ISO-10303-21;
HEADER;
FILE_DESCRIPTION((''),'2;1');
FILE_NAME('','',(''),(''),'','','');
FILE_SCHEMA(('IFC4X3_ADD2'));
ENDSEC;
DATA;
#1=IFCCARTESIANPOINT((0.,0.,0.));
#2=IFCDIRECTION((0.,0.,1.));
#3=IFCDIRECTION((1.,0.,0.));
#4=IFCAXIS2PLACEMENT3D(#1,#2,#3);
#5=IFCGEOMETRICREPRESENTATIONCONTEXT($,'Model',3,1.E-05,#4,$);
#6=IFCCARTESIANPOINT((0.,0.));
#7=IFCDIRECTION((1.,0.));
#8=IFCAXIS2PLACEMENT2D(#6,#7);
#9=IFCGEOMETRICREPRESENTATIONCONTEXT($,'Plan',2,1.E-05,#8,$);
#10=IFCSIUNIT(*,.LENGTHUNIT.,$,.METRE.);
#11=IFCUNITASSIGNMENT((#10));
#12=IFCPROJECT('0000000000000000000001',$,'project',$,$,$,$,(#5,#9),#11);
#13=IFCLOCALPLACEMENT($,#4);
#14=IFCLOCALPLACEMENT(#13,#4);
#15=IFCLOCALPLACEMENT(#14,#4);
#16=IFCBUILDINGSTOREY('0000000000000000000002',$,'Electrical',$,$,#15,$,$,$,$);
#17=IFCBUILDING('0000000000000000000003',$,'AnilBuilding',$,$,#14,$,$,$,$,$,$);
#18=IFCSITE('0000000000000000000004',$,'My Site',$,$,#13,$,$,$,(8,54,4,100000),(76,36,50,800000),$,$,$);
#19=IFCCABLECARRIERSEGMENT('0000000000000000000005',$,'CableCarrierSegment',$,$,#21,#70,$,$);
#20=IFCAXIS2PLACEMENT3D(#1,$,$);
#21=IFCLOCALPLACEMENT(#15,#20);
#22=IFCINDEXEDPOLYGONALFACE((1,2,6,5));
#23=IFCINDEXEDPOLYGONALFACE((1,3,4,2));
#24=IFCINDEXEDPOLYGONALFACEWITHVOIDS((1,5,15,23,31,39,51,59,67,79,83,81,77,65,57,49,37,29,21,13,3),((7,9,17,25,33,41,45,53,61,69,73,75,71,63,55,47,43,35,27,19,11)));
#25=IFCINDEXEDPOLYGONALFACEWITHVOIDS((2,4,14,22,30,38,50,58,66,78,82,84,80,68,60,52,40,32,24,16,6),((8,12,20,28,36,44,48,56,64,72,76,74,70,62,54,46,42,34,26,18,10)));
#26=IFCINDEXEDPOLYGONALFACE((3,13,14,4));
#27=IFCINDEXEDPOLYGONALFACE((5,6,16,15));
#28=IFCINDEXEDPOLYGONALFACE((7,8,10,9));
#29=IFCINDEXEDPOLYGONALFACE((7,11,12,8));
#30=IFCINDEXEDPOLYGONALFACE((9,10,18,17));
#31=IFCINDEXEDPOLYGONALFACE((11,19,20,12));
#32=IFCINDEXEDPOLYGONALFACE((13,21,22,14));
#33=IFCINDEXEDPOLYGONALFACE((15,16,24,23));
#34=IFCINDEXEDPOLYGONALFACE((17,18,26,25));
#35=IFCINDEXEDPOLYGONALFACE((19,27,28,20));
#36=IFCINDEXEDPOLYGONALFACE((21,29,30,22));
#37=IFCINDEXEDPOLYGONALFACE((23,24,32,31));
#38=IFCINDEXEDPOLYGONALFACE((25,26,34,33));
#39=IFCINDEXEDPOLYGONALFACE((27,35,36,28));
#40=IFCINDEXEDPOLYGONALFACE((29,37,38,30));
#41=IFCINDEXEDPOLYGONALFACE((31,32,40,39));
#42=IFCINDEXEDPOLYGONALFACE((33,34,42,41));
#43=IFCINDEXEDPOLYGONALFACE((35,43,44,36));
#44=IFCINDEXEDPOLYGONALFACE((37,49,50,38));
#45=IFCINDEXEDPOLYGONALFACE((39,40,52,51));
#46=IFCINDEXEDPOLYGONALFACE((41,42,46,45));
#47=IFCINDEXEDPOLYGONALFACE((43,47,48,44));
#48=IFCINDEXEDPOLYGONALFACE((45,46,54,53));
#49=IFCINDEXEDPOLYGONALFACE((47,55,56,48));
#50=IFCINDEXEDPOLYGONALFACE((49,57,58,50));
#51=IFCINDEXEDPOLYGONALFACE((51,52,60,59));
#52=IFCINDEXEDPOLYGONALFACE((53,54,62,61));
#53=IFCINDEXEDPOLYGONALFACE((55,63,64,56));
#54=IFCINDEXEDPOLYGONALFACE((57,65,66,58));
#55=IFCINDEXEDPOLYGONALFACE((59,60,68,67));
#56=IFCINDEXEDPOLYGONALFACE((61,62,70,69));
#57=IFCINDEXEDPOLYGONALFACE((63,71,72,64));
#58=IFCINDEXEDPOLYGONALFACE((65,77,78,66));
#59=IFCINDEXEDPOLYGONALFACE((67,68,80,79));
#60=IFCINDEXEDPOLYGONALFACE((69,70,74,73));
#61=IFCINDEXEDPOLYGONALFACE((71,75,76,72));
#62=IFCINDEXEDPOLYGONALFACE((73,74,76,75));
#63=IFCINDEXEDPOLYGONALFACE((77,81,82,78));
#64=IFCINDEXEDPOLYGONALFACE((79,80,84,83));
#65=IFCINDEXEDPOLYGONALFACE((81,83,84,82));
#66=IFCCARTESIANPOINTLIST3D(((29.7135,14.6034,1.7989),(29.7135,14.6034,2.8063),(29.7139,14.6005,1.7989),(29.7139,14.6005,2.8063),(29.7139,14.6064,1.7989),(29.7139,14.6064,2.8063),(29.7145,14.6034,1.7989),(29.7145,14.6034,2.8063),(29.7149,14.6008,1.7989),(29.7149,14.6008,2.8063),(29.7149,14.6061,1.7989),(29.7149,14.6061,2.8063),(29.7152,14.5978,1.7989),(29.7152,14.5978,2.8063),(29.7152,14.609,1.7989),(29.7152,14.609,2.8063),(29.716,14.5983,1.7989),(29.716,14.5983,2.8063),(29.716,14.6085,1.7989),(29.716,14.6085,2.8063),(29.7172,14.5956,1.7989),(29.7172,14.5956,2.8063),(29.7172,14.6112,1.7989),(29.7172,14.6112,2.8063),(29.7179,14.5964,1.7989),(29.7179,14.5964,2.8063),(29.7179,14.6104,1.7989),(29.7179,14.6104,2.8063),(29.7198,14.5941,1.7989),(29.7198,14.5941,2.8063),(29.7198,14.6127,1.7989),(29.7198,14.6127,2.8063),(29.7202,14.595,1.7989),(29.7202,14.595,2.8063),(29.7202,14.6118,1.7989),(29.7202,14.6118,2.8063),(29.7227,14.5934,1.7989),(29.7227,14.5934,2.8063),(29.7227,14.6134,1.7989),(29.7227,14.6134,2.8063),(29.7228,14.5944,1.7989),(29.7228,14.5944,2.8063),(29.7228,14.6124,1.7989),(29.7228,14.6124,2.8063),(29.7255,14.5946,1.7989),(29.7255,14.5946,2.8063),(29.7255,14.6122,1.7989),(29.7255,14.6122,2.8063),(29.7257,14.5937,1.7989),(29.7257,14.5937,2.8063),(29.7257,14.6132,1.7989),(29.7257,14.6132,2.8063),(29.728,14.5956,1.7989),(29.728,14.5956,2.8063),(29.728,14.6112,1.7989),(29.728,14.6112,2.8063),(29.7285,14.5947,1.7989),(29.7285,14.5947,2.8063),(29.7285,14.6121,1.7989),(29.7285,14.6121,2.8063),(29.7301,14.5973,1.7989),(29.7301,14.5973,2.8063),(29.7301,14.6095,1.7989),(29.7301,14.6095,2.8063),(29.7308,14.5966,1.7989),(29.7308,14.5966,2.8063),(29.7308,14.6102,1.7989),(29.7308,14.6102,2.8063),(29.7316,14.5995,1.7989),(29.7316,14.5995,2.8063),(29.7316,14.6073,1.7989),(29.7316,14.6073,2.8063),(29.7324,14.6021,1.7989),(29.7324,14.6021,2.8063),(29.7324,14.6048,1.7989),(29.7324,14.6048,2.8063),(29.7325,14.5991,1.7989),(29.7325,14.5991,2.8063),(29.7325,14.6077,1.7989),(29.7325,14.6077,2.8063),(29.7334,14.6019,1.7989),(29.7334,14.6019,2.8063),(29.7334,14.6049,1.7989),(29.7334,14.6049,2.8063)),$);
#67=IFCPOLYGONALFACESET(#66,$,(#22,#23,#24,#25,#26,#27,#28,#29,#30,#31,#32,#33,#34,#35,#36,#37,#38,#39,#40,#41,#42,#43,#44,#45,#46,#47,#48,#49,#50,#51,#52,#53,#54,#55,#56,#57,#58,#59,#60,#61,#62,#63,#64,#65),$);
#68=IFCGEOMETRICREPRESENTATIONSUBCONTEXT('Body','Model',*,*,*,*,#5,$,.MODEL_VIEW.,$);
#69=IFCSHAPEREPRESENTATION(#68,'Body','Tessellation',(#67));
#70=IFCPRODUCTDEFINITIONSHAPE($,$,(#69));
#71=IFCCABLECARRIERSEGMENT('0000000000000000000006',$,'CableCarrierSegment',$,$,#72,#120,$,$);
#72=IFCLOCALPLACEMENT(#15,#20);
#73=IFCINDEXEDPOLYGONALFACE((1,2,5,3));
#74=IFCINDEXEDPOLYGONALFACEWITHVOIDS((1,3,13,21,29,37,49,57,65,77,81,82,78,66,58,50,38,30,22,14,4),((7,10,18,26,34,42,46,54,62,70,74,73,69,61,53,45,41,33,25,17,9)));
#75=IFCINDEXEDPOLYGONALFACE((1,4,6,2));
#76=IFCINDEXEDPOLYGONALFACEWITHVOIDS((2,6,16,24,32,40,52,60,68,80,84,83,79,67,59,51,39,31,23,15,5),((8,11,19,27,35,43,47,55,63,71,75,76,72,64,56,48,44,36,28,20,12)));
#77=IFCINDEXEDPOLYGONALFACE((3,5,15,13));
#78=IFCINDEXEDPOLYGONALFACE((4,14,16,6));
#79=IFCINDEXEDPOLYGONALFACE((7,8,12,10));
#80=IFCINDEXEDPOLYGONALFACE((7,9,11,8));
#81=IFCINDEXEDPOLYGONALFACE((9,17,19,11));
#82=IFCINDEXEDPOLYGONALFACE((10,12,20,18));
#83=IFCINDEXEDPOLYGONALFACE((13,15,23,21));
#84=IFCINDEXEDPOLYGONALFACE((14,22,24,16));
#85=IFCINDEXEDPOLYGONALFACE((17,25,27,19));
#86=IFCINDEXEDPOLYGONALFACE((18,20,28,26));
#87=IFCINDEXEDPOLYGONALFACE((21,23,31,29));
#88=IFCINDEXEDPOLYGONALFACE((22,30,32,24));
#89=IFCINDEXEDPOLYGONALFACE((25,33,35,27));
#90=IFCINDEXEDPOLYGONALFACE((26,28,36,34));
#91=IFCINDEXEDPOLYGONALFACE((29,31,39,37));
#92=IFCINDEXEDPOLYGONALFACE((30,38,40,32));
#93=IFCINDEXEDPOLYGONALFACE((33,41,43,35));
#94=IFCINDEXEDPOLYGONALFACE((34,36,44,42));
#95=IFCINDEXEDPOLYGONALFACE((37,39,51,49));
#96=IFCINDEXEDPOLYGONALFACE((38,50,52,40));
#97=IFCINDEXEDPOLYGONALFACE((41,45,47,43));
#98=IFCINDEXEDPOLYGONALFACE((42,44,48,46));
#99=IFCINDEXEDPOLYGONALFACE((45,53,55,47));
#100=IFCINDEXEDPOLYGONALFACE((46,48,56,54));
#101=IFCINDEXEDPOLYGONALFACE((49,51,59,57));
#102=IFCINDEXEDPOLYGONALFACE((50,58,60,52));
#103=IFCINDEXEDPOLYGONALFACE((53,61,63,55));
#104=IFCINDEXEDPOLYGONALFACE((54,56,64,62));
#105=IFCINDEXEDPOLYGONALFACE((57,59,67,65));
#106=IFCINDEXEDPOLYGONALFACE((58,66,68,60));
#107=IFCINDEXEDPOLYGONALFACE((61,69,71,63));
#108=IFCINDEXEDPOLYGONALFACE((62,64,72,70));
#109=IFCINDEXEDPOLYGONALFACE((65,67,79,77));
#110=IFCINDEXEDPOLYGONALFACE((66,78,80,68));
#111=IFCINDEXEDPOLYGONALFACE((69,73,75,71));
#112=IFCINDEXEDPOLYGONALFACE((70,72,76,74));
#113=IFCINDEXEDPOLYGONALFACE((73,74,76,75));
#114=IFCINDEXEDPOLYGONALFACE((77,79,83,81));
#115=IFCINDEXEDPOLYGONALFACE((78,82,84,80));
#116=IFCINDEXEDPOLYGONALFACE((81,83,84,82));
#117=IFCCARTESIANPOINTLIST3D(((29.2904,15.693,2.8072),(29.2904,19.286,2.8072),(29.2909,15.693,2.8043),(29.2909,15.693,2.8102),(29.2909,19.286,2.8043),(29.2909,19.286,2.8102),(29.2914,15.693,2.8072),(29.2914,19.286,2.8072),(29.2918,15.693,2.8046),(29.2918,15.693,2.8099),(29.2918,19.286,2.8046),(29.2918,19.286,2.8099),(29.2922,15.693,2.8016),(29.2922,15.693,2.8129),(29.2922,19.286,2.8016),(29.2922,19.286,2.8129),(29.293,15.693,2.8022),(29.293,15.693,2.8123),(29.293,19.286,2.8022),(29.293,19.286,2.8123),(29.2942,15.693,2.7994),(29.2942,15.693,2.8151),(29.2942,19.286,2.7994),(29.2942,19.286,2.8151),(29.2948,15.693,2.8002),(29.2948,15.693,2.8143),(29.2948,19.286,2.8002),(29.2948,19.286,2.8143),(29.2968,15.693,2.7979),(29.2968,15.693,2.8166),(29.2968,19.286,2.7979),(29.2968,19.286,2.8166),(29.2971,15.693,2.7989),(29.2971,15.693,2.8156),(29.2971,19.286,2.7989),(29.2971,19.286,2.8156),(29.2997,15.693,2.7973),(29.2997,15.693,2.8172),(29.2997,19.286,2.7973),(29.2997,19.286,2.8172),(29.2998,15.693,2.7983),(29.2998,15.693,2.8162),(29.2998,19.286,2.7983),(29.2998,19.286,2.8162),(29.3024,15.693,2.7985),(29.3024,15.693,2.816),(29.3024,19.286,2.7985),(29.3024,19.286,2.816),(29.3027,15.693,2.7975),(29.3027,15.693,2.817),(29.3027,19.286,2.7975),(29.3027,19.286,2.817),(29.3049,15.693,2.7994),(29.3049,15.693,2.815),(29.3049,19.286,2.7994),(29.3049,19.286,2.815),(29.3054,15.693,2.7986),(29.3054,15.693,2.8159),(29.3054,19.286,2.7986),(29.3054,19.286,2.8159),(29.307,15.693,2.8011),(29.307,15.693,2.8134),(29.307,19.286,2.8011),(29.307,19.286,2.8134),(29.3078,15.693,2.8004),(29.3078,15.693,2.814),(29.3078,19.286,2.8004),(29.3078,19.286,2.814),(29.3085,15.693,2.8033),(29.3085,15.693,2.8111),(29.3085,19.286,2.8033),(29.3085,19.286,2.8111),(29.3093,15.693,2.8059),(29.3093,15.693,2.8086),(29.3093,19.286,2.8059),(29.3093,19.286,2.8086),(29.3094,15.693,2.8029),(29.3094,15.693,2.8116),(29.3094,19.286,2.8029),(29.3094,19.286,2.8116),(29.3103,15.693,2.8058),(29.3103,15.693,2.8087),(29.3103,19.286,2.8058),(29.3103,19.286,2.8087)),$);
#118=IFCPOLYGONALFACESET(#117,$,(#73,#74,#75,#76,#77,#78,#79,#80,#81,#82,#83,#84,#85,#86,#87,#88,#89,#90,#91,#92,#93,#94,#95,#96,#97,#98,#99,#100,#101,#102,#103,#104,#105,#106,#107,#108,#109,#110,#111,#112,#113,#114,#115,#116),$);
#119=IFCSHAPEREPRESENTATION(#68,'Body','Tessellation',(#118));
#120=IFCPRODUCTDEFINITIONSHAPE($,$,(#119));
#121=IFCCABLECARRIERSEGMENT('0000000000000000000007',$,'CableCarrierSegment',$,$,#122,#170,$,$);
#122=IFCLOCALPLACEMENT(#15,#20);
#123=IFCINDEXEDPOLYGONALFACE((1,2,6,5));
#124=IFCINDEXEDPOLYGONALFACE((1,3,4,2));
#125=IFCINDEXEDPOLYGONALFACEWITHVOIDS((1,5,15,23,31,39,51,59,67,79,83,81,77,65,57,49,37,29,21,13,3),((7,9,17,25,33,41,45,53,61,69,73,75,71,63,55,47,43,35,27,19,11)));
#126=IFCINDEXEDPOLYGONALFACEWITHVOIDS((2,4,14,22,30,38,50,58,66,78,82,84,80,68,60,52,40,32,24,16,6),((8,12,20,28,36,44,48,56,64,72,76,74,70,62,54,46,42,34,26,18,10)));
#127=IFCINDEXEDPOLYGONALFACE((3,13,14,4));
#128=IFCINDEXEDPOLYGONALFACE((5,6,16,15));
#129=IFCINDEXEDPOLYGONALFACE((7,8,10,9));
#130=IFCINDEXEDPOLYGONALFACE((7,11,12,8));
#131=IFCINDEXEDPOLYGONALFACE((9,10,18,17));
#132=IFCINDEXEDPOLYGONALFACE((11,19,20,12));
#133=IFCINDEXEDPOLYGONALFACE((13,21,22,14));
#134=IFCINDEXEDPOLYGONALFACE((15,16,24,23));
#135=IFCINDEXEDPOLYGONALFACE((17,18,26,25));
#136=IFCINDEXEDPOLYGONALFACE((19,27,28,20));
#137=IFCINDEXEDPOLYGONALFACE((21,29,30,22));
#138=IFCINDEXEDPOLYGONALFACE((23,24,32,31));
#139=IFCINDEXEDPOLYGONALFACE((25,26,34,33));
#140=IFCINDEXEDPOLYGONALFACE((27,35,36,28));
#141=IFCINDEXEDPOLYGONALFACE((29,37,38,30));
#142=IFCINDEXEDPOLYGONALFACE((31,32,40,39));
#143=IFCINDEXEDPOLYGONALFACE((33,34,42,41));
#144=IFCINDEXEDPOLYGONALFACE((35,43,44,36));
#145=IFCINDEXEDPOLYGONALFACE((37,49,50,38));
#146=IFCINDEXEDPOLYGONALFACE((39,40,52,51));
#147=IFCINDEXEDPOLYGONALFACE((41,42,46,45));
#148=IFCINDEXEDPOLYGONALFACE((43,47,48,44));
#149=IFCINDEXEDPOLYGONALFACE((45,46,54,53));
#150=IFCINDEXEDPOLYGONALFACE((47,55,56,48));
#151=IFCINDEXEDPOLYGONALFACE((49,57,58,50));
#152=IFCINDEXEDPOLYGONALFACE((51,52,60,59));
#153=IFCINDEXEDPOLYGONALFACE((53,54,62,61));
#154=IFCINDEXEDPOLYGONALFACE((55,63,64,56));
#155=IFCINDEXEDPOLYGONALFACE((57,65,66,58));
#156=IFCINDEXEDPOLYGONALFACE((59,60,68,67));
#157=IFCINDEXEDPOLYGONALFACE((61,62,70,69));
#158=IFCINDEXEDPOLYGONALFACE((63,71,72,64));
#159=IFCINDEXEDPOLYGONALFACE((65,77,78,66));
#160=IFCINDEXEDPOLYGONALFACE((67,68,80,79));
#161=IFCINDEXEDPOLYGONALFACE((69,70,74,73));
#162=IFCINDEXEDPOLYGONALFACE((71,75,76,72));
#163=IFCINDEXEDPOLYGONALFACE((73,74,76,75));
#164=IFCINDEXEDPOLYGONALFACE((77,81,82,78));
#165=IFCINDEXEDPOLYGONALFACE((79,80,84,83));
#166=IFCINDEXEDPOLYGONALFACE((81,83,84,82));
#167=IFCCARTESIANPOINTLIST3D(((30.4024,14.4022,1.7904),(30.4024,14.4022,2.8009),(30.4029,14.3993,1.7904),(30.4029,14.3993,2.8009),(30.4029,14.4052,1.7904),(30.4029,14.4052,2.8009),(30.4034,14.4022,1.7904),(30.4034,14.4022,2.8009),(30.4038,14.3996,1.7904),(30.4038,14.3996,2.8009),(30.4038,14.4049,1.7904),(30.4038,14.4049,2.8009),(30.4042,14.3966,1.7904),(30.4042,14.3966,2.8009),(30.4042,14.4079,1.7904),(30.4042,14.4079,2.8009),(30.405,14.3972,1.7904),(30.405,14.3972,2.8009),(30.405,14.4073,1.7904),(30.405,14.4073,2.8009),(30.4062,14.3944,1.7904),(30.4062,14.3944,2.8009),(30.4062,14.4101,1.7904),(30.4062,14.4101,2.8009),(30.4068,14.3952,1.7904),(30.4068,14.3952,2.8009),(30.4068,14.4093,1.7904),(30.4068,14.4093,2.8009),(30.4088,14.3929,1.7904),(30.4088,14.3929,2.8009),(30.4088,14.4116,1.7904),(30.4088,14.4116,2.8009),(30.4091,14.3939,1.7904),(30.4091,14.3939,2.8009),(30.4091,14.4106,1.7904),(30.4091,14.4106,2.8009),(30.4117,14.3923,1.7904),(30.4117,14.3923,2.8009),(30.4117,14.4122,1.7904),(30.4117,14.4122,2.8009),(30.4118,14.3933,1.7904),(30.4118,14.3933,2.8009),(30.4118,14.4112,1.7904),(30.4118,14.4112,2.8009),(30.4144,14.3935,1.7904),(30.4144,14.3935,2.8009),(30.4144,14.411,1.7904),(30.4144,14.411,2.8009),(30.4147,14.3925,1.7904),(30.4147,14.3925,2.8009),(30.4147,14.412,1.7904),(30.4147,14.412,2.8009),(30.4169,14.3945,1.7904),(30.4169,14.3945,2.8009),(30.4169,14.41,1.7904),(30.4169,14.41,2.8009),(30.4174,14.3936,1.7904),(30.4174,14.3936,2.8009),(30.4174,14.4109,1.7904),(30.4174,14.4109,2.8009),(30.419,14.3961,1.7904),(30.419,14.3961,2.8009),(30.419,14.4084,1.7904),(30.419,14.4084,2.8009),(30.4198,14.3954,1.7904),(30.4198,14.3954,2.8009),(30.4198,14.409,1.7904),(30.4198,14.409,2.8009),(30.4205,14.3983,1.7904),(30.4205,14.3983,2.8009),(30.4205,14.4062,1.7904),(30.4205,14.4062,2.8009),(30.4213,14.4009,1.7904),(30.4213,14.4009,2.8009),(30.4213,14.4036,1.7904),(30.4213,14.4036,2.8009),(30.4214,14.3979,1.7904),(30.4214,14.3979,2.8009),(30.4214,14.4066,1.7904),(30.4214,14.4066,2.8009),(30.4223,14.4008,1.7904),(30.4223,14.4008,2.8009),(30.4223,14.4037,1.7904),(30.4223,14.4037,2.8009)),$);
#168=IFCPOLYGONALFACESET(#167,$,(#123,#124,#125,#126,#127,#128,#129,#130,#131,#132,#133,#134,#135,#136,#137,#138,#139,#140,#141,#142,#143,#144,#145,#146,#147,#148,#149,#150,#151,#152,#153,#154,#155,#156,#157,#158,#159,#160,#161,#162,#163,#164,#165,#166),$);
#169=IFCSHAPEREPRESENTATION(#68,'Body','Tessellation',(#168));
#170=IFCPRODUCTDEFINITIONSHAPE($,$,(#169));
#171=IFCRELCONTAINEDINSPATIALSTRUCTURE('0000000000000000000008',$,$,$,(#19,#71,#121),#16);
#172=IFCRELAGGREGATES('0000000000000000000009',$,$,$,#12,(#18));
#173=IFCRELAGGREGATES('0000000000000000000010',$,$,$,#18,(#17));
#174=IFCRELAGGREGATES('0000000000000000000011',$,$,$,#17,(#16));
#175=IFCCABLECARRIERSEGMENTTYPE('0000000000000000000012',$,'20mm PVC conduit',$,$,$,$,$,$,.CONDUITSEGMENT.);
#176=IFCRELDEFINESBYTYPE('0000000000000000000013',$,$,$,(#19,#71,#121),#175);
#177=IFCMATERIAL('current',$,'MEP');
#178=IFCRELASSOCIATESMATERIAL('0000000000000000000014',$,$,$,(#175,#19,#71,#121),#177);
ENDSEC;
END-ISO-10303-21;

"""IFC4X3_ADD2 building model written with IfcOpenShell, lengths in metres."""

from ifc_helpers import new_model, si_unit, frame, origin_with_axes, origin_2d_with_axis, place, context, subcontext, project, spatial, hollow_circle, extrude, material, material_profile, profile_set, profile_usage, type_object, element, save


model = new_model("IFC4X3_ADD2")

# Units and contexts
model_context = context("Model", 3, precision=1e-05, world=origin_with_axes())
plan_context = context("Plan", 2, precision=1e-05, world=origin_2d_with_axis())
body_context = subcontext(model_context, "Body", "Model", "MODEL_VIEW")
ifc_project = project(units=[si_unit("LENGTHUNIT", "METRE")], contexts=[model_context, plan_context])

# Site, building, storey
site_placement = place(None, origin_with_axes())
site = spatial("IfcSite", under=ifc_project, at=site_placement, Name="My Site", RefLatitude=(8, 54, 4, 100000), RefLongitude=(76, 36, 50, 800000))
building_placement = place(site_placement, origin_with_axes())
building = spatial("IfcBuilding", under=site, at=building_placement, Name="AnilBuilding")
storey_placement = place(building_placement, origin_with_axes())
storey = spatial("IfcBuildingStorey", under=building, at=storey_placement, Name="Electrical")

# Cable carrier segments
ifc_material = material(Name="current", Category="MEP")
ifc_material_profile_1 = material_profile(ifc_material, hollow_circle(Radius=0.01, WallThickness=0.001))
ifc_profile_set_1 = profile_set([ifc_material_profile_1], Name="current")
ifc_material_profile_2 = material_profile(ifc_material, hollow_circle(Radius=0.01, WallThickness=0.001))
ifc_profile_set_2 = profile_set([ifc_material_profile_2], Name="current")
cable_carrier_segment_type = type_object("IfcCableCarrierSegmentType", Name="20mm PVC conduit", PredefinedType="CONDUITSEGMENT", material=ifc_profile_set_2)
ifc_profile_usage_1 = profile_usage(ifc_profile_set_1, cardinal=5)
cable_carrier_segment_1_placement = place(storey_placement, frame((29.7235, 14.6034, 1.7989), z_axis=(0.0, 0.0, 1.0), x_axis=(-1.0, 0.0, 0.0)))
element("IfcCableCarrierSegment", 1, at=cable_carrier_segment_1_placement, inside=storey, type_object=cable_carrier_segment_type, material=ifc_profile_usage_1, Name="CableCarrierSegment", context=body_context, shape_type="SweptSolid", body=[
    extrude(hollow_circle(Radius=0.01, WallThickness=0.001), origin_with_axes(), (0.0, 0.0, 1.0), 1.0073),
])
ifc_profile_usage_2 = profile_usage(ifc_profile_set_1, cardinal=5)
cable_carrier_segment_2_placement = place(storey_placement, frame((29.3004, 15.693, 2.8072), z_axis=(0.0, 1.0, 0.0), x_axis=(-1.0, 0.0, 0.0)))
element("IfcCableCarrierSegment", 2, at=cable_carrier_segment_2_placement, inside=storey, type_object=cable_carrier_segment_type, material=ifc_profile_usage_2, Name="CableCarrierSegment", context=body_context, shape_type="SweptSolid", body=[
    extrude(hollow_circle(Radius=0.01, WallThickness=0.001), origin_with_axes(), (0.0, 0.0, 1.0), 3.5929),
])
ifc_profile_usage_3 = profile_usage(ifc_profile_set_1, cardinal=5)
cable_carrier_segment_3_placement = place(storey_placement, frame((30.4124, 14.4022, 1.7904), z_axis=(0.0, 0.0, 1.0), x_axis=(-1.0, 0.0, 0.0)))
element("IfcCableCarrierSegment", 3, at=cable_carrier_segment_3_placement, inside=storey, type_object=cable_carrier_segment_type, material=ifc_profile_usage_3, Name="CableCarrierSegment", context=body_context, shape_type="SweptSolid", body=[
    extrude(hollow_circle(Radius=0.01, WallThickness=0.001), origin_with_axes(), (0.0, 0.0, 1.0), 1.0105),
])

save(model, "model.ifc")
